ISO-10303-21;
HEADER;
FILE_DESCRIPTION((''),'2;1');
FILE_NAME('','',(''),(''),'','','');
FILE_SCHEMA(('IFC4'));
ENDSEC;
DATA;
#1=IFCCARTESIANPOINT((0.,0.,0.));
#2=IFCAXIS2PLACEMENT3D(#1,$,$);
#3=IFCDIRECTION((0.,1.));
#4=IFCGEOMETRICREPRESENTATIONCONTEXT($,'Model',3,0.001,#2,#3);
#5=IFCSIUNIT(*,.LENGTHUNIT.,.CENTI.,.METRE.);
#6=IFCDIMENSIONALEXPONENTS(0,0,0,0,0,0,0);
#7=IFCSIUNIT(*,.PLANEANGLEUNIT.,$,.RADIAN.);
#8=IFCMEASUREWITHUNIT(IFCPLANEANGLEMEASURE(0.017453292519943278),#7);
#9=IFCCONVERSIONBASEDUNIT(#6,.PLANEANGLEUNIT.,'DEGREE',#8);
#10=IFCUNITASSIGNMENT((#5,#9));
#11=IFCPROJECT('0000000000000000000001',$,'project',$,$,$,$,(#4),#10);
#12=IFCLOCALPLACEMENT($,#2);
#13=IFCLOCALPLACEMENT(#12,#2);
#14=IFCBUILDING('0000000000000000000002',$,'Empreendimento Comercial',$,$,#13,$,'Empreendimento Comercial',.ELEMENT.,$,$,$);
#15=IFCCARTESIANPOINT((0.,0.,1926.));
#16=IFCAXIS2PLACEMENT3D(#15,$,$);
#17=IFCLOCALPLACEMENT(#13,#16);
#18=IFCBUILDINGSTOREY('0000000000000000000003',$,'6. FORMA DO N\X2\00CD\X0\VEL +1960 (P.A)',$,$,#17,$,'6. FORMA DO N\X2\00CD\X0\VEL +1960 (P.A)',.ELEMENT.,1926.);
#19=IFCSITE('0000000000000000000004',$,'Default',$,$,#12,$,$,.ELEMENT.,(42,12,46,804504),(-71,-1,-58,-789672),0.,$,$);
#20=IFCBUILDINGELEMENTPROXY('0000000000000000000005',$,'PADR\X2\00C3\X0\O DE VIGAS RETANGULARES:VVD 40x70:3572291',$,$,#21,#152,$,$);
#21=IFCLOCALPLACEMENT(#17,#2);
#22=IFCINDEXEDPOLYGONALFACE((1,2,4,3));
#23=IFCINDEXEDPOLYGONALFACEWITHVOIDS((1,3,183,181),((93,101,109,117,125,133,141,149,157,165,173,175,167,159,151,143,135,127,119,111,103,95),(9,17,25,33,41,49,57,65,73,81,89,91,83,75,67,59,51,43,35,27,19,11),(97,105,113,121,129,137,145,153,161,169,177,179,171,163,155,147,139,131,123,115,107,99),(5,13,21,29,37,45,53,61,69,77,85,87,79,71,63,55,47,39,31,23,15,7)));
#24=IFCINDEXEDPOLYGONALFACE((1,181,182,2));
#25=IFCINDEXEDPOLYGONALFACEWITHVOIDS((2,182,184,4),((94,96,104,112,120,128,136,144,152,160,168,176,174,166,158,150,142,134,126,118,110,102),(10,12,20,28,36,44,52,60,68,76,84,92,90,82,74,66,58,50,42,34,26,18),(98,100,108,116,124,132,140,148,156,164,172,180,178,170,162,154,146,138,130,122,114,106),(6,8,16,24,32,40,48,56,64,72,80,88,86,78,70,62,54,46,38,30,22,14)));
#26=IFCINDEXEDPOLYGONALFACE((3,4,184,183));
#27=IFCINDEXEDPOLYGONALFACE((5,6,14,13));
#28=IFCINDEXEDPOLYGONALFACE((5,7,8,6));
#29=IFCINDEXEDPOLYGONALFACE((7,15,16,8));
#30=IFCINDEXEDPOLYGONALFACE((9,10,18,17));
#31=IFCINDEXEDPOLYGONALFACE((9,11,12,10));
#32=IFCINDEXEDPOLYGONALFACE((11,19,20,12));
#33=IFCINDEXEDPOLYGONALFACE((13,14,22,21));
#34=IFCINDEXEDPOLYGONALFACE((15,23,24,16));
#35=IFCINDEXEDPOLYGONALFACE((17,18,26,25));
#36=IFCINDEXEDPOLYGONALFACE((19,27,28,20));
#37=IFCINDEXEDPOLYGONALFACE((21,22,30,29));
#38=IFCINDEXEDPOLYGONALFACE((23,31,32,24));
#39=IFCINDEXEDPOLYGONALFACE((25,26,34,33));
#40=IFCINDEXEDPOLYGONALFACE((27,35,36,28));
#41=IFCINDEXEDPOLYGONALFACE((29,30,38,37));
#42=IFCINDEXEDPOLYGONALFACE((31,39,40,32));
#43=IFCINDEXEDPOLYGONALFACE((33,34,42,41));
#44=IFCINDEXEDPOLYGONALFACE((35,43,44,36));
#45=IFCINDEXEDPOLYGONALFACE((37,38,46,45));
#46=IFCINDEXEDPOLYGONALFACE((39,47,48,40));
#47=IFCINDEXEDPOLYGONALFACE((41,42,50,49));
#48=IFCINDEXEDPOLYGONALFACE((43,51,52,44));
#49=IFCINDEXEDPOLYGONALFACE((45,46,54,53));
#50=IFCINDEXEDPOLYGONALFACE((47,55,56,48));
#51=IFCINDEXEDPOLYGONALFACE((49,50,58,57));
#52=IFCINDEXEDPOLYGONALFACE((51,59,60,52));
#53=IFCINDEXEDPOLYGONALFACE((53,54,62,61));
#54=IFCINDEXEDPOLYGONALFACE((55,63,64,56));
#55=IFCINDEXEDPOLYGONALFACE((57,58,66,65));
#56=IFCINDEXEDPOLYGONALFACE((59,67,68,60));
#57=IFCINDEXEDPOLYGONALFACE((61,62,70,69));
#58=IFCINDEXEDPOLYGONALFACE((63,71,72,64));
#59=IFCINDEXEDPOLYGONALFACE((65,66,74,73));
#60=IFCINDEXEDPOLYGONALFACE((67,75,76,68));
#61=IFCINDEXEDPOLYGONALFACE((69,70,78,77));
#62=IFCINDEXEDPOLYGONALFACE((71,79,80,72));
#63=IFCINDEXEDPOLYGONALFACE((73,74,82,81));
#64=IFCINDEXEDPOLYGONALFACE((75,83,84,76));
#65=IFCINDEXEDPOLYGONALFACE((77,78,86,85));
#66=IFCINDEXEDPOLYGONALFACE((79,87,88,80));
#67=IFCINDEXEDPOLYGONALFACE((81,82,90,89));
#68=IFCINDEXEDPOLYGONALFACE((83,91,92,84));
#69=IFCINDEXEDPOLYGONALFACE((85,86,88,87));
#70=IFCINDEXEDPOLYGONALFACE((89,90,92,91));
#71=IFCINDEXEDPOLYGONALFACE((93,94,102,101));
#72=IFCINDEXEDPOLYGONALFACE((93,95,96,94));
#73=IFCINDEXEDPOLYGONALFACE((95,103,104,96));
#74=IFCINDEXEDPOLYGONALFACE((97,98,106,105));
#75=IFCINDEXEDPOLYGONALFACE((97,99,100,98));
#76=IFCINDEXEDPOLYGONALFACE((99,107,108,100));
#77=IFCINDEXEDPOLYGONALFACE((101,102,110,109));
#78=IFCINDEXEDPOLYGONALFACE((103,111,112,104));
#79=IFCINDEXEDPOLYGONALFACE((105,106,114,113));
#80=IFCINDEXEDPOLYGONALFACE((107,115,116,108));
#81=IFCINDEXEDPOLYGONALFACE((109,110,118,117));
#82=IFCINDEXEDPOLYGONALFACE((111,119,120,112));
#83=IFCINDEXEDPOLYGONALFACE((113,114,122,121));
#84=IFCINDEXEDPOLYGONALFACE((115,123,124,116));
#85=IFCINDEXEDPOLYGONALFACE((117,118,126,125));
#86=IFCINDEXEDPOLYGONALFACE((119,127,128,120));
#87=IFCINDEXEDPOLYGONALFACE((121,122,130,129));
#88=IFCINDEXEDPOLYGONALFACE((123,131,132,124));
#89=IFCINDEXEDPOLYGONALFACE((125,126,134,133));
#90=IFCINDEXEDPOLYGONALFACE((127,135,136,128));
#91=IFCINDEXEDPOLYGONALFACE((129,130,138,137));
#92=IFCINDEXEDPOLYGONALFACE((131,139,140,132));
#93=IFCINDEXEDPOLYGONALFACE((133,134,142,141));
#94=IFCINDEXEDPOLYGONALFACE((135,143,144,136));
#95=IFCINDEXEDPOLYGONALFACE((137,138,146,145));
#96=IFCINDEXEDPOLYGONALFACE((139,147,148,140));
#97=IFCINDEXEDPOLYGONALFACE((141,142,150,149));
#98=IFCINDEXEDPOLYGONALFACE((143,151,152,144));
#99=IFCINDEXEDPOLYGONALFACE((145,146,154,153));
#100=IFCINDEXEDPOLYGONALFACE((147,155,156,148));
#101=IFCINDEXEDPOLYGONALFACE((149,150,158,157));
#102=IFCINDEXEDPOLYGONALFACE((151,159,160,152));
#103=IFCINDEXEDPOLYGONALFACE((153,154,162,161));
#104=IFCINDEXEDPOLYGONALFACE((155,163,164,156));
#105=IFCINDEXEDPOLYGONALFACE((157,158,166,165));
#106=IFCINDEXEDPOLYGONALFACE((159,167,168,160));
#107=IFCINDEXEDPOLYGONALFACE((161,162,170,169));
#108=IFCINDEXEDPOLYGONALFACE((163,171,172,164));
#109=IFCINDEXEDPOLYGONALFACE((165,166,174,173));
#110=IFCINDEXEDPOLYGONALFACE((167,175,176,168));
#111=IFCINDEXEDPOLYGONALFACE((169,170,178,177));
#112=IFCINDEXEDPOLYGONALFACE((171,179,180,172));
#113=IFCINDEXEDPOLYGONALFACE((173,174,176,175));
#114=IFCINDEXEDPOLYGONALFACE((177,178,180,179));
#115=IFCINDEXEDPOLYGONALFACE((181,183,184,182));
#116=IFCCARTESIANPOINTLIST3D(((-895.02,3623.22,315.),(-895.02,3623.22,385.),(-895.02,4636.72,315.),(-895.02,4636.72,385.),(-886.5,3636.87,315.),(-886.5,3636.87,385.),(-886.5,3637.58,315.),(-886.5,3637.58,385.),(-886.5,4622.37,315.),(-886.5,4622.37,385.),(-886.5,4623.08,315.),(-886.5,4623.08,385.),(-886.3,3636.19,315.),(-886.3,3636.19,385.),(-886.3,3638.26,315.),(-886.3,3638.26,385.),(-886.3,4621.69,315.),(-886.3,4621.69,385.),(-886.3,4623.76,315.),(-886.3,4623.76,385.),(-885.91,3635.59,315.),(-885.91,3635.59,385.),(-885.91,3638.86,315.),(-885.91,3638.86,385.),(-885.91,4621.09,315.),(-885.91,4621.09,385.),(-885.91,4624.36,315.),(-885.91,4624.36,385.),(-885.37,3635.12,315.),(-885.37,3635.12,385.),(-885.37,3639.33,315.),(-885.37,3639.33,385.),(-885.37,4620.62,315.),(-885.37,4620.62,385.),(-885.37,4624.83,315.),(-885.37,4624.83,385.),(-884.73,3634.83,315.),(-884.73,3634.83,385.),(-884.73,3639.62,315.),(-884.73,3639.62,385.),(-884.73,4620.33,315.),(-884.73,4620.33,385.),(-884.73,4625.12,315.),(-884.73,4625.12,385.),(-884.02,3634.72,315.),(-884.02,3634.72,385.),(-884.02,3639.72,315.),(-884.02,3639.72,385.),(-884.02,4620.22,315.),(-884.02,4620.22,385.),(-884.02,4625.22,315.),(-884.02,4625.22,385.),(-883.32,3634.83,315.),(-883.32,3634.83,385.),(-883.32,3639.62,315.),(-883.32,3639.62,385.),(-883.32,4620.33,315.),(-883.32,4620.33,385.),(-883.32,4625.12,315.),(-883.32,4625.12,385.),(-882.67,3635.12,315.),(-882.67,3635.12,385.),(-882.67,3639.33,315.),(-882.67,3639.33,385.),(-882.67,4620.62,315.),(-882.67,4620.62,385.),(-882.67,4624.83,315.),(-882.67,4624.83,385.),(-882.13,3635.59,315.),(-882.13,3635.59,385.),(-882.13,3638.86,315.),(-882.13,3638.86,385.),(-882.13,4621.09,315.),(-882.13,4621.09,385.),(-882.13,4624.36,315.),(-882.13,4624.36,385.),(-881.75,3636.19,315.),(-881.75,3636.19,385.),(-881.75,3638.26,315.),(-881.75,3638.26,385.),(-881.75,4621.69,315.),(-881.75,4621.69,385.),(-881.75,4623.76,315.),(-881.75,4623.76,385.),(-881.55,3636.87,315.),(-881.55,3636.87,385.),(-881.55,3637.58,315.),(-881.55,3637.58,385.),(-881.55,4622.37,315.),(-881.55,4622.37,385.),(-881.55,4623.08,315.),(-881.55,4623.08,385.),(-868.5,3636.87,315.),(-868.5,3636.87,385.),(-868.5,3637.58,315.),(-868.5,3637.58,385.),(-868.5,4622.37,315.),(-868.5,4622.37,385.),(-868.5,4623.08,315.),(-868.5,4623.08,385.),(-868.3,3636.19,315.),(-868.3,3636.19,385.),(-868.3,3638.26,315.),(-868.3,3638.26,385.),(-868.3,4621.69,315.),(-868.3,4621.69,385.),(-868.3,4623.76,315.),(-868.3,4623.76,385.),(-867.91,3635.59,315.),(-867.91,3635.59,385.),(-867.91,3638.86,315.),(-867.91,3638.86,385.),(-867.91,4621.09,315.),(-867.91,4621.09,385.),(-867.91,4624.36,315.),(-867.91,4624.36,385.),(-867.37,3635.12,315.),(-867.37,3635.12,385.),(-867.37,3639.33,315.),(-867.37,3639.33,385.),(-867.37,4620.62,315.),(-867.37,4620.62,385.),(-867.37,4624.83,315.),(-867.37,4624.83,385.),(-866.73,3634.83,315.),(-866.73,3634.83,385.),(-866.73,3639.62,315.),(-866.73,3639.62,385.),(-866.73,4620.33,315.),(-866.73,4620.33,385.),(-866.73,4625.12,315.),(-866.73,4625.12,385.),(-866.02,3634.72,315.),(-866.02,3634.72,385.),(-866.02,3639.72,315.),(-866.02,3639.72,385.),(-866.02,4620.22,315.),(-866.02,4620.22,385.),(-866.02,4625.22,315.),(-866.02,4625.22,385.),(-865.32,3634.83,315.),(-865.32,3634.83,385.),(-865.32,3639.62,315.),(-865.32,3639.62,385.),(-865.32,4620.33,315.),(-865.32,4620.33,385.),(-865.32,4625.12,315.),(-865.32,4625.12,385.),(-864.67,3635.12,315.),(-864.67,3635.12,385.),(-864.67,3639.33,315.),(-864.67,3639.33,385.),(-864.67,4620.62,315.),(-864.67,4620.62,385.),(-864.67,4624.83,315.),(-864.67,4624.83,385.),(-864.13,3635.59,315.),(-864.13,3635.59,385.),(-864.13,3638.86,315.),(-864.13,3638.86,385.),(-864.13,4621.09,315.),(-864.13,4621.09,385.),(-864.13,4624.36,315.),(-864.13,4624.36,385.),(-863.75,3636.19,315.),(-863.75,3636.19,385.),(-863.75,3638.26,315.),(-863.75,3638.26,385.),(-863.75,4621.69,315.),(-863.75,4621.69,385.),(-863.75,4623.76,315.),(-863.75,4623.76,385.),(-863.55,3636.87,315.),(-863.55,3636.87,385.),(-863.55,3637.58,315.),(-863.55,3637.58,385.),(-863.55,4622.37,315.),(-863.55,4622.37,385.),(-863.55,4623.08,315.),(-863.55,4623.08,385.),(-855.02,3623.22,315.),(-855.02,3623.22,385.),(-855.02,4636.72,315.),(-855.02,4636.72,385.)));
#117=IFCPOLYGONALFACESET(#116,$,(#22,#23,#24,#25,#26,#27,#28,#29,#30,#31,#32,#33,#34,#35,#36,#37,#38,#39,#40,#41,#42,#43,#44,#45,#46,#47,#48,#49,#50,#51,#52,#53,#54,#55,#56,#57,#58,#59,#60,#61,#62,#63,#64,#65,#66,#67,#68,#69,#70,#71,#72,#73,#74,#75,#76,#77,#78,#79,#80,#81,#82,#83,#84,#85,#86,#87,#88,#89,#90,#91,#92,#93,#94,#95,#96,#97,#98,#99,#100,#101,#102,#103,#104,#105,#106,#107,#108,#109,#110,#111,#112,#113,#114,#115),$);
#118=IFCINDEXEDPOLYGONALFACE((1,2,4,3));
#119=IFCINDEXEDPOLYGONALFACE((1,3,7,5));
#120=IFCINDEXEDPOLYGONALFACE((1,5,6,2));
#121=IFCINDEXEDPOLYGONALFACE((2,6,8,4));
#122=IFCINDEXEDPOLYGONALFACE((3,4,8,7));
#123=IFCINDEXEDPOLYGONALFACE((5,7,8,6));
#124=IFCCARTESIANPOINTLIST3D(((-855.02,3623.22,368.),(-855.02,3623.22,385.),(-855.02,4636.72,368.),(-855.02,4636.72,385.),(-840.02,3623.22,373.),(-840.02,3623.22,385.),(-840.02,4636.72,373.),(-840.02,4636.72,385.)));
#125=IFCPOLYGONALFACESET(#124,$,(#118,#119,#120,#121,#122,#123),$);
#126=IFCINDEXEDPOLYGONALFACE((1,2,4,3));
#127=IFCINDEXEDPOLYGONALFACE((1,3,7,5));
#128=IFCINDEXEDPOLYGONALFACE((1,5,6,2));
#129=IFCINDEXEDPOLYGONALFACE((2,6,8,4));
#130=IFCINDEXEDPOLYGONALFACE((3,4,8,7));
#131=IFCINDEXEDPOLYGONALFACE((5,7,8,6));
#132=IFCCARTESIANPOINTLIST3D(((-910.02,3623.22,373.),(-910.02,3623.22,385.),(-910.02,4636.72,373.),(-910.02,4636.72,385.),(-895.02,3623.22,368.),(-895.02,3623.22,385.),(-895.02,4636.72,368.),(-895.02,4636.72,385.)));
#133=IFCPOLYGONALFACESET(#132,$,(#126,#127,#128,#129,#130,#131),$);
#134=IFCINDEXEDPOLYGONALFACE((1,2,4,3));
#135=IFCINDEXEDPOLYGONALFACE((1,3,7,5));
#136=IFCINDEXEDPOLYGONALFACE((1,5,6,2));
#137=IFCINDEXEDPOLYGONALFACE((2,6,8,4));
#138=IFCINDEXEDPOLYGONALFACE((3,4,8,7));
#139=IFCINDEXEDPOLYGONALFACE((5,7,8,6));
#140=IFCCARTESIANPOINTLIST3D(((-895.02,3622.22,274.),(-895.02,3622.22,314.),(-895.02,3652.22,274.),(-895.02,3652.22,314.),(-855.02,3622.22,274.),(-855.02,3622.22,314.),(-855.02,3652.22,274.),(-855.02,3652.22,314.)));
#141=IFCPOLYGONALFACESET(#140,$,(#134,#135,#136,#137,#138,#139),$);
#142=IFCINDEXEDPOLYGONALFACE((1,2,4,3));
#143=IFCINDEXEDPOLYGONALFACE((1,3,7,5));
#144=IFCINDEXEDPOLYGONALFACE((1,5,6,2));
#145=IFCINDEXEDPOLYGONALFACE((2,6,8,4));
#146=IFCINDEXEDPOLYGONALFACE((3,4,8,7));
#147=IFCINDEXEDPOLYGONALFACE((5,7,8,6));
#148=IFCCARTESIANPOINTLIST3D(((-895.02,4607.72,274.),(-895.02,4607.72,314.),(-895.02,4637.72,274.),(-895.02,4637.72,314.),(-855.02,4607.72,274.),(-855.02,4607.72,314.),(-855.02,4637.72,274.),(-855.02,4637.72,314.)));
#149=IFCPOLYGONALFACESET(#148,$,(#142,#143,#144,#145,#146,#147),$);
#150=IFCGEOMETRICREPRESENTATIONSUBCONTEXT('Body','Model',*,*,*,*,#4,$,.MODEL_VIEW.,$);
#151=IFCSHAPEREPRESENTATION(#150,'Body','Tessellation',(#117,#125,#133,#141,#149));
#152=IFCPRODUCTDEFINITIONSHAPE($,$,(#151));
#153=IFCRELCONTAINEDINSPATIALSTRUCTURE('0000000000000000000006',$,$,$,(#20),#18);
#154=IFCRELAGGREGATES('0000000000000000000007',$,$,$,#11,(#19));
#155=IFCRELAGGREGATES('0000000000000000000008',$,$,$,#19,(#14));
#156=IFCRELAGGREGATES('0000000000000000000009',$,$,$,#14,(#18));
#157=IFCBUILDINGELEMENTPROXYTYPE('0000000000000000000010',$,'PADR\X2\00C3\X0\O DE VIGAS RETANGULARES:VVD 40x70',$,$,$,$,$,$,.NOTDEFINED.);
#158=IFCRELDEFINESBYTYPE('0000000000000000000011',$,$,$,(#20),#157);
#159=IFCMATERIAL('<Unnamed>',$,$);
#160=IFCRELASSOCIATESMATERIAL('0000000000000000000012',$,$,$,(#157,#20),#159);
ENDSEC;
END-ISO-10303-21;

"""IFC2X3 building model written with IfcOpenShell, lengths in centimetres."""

from ifc_helpers import new_model, entity, si_unit, converted_unit, direction, frame, frame_2d, origin, place, context, subcontext, project, spatial, polyline, circle_curve, parameter, trimmed, segment, composite_curve, rectangle, outline, extrude, source, transform, mapped, material, type_object, type_shapes, element, save


model = new_model("IFC2X3")

# Units and contexts
model_context = context("Model", 3, precision=0.001, world=origin(), true_north=direction((0.0, 1.0)))
body_context = subcontext(model_context, "Body", "Model", "MODEL_VIEW")
ifc_project = project(units=[si_unit("LENGTHUNIT", "METRE", prefix="CENTI"), converted_unit("PLANEANGLEUNIT", "DEGREE", entity("IfcPlaneAngleMeasure", 0.017453292519943278), si_unit("PLANEANGLEUNIT", "RADIAN"), dimensions=[0, 0, 0, 0, 0, 0, 0])], contexts=[model_context])

# Site, building, storey
site_placement = place(None, origin())
site = spatial("IfcSite", under=ifc_project, at=site_placement, Name="Default", CompositionType="ELEMENT", RefLatitude=(42, 12, 46, 804504), RefLongitude=(-71, -1, -58, -789672), RefElevation=0.0)
building_placement = place(site_placement, origin())
building = spatial("IfcBuilding", under=site, at=building_placement, Name="Empreendimento Comercial", LongName="Empreendimento Comercial", CompositionType="ELEMENT")
storey_placement = place(building_placement, frame((0.0, 0.0, 1926.0)))
storey = spatial("IfcBuildingStorey", under=building, at=storey_placement, Name="6. FORMA DO NÍVEL +1960 (P.A)", LongName="6. FORMA DO NÍVEL +1960 (P.A)", CompositionType="ELEMENT", Elevation=1926.0)

# Building element proxy
ifc_material = material(Name="<Unnamed>")
building_element_proxy_type_1 = type_object("IfcBuildingElementProxyType", Name="PADRÃO DE VIGAS RETANGULARES:VVD 40x70", PredefinedType="NOTDEFINED", material=ifc_material)
shared_shape_1 = source(origin(), body_context, "Body", "SweptSolid", [
    extrude(outline(polyline([(-506.75, -20.0), (506.75, -20.0), (506.75, 20.0), (-506.75, 20.0), (-506.75, -20.0)]), holes=[composite_curve([segment(trimmed(circle_curve(frame_2d((-492.75, -9.0), x_axis=(-1.0, 0.0)), 2.5), [parameter(0.0)], [parameter(180.0)], True, "PARAMETER"), False, "CONTINUOUS"), segment(trimmed(circle_curve(frame_2d((-492.75, -9.0), x_axis=(-1.0, 0.0)), 2.5), [parameter(180.0)], [parameter(0.0)], True, "PARAMETER"), False, "CONTINUOUS")], self_intersect=False), composite_curve([segment(trimmed(circle_curve(frame_2d((-492.75, 9.0), x_axis=(-1.0, 0.0)), 2.5), [parameter(0.0)], [parameter(180.0)], True, "PARAMETER"), False, "CONTINUOUS"), segment(trimmed(circle_curve(frame_2d((-492.75, 9.0), x_axis=(-1.0, 0.0)), 2.5), [parameter(180.0)], [parameter(0.0)], True, "PARAMETER"), False, "CONTINUOUS")], self_intersect=False), composite_curve([segment(trimmed(circle_curve(frame_2d((492.75, 9.0), x_axis=(-1.0, 0.0)), 2.5), [parameter(0.0)], [parameter(180.0)], True, "PARAMETER"), False, "CONTINUOUS"), segment(trimmed(circle_curve(frame_2d((492.75, 9.0), x_axis=(-1.0, 0.0)), 2.5), [parameter(180.0)], [parameter(0.0)], True, "PARAMETER"), False, "CONTINUOUS")], self_intersect=False), composite_curve([segment(trimmed(circle_curve(frame_2d((492.75, -9.0), x_axis=(-1.0, 0.0)), 2.5), [parameter(0.0)], [parameter(180.0)], True, "PARAMETER"), False, "CONTINUOUS"), segment(trimmed(circle_curve(frame_2d((492.75, -9.0), x_axis=(-1.0, 0.0)), 2.5), [parameter(180.0)], [parameter(0.0)], True, "PARAMETER"), False, "CONTINUOUS")], self_intersect=False)]), frame((-875.02, 4129.97, 2241.0), z_axis=(0.0, 0.0, 1.0), x_axis=(0.0, -1.0, 0.0)), (0.0, 0.0, 1.0), 70.0),
    extrude(outline(polyline([(-7.25, -7.5), (4.75, -7.5), (9.75, 7.5), (-7.25, 7.5), (-7.25, -7.5)])), frame((-847.52, 3623.22, 2303.75), z_axis=(0.0, 1.0, 0.0), x_axis=(0.0, 0.0, -1.0)), (0.0, 0.0, 1.0), 1013.5),
    extrude(outline(polyline([(-7.5, -7.25), (7.5, -7.25), (7.5, 9.75), (-7.5, 4.75), (-7.5, -7.25)])), frame((-902.52, 3623.22, 2303.75), z_axis=(0.0, 1.0, 0.0), x_axis=(1.0, 0.0, 0.0)), (0.0, 0.0, 1.0), 1013.5),
    extrude(rectangle(XDim=40.0, YDim=30.0, at=frame_2d((0.0, 0.0), x_axis=(1.0, 0.0))), frame((-875.02, 3637.22, 2200.0), z_axis=(0.0, 0.0, 1.0), x_axis=(-1.0, 0.0, 0.0)), (0.0, 0.0, 1.0), 40.0),
    extrude(rectangle(XDim=40.0, YDim=30.0, at=frame_2d((0.0, 0.0), x_axis=(1.0, 0.0))), frame((-875.02, 4622.72, 2200.0), z_axis=(0.0, 0.0, 1.0), x_axis=(-1.0, 0.0, 0.0)), (0.0, 0.0, 1.0), 40.0),
])
type_shapes(building_element_proxy_type_1, [shared_shape_1])
proxy_1_placement = place(storey_placement, frame((0.0, 0.0, -1926.0)))
element("IfcBuildingElementProxy", 1, at=proxy_1_placement, inside=storey, type_object=building_element_proxy_type_1, material=ifc_material, Name="PADRÃO DE VIGAS RETANGULARES:VVD 40x70:3572291", context=body_context, shape_type="MappedRepresentation", body=[
    mapped(shared_shape_1, transform((0.0, 0.0, 0.0), scale=1.0)),
])

save(model, "model.ifc")
